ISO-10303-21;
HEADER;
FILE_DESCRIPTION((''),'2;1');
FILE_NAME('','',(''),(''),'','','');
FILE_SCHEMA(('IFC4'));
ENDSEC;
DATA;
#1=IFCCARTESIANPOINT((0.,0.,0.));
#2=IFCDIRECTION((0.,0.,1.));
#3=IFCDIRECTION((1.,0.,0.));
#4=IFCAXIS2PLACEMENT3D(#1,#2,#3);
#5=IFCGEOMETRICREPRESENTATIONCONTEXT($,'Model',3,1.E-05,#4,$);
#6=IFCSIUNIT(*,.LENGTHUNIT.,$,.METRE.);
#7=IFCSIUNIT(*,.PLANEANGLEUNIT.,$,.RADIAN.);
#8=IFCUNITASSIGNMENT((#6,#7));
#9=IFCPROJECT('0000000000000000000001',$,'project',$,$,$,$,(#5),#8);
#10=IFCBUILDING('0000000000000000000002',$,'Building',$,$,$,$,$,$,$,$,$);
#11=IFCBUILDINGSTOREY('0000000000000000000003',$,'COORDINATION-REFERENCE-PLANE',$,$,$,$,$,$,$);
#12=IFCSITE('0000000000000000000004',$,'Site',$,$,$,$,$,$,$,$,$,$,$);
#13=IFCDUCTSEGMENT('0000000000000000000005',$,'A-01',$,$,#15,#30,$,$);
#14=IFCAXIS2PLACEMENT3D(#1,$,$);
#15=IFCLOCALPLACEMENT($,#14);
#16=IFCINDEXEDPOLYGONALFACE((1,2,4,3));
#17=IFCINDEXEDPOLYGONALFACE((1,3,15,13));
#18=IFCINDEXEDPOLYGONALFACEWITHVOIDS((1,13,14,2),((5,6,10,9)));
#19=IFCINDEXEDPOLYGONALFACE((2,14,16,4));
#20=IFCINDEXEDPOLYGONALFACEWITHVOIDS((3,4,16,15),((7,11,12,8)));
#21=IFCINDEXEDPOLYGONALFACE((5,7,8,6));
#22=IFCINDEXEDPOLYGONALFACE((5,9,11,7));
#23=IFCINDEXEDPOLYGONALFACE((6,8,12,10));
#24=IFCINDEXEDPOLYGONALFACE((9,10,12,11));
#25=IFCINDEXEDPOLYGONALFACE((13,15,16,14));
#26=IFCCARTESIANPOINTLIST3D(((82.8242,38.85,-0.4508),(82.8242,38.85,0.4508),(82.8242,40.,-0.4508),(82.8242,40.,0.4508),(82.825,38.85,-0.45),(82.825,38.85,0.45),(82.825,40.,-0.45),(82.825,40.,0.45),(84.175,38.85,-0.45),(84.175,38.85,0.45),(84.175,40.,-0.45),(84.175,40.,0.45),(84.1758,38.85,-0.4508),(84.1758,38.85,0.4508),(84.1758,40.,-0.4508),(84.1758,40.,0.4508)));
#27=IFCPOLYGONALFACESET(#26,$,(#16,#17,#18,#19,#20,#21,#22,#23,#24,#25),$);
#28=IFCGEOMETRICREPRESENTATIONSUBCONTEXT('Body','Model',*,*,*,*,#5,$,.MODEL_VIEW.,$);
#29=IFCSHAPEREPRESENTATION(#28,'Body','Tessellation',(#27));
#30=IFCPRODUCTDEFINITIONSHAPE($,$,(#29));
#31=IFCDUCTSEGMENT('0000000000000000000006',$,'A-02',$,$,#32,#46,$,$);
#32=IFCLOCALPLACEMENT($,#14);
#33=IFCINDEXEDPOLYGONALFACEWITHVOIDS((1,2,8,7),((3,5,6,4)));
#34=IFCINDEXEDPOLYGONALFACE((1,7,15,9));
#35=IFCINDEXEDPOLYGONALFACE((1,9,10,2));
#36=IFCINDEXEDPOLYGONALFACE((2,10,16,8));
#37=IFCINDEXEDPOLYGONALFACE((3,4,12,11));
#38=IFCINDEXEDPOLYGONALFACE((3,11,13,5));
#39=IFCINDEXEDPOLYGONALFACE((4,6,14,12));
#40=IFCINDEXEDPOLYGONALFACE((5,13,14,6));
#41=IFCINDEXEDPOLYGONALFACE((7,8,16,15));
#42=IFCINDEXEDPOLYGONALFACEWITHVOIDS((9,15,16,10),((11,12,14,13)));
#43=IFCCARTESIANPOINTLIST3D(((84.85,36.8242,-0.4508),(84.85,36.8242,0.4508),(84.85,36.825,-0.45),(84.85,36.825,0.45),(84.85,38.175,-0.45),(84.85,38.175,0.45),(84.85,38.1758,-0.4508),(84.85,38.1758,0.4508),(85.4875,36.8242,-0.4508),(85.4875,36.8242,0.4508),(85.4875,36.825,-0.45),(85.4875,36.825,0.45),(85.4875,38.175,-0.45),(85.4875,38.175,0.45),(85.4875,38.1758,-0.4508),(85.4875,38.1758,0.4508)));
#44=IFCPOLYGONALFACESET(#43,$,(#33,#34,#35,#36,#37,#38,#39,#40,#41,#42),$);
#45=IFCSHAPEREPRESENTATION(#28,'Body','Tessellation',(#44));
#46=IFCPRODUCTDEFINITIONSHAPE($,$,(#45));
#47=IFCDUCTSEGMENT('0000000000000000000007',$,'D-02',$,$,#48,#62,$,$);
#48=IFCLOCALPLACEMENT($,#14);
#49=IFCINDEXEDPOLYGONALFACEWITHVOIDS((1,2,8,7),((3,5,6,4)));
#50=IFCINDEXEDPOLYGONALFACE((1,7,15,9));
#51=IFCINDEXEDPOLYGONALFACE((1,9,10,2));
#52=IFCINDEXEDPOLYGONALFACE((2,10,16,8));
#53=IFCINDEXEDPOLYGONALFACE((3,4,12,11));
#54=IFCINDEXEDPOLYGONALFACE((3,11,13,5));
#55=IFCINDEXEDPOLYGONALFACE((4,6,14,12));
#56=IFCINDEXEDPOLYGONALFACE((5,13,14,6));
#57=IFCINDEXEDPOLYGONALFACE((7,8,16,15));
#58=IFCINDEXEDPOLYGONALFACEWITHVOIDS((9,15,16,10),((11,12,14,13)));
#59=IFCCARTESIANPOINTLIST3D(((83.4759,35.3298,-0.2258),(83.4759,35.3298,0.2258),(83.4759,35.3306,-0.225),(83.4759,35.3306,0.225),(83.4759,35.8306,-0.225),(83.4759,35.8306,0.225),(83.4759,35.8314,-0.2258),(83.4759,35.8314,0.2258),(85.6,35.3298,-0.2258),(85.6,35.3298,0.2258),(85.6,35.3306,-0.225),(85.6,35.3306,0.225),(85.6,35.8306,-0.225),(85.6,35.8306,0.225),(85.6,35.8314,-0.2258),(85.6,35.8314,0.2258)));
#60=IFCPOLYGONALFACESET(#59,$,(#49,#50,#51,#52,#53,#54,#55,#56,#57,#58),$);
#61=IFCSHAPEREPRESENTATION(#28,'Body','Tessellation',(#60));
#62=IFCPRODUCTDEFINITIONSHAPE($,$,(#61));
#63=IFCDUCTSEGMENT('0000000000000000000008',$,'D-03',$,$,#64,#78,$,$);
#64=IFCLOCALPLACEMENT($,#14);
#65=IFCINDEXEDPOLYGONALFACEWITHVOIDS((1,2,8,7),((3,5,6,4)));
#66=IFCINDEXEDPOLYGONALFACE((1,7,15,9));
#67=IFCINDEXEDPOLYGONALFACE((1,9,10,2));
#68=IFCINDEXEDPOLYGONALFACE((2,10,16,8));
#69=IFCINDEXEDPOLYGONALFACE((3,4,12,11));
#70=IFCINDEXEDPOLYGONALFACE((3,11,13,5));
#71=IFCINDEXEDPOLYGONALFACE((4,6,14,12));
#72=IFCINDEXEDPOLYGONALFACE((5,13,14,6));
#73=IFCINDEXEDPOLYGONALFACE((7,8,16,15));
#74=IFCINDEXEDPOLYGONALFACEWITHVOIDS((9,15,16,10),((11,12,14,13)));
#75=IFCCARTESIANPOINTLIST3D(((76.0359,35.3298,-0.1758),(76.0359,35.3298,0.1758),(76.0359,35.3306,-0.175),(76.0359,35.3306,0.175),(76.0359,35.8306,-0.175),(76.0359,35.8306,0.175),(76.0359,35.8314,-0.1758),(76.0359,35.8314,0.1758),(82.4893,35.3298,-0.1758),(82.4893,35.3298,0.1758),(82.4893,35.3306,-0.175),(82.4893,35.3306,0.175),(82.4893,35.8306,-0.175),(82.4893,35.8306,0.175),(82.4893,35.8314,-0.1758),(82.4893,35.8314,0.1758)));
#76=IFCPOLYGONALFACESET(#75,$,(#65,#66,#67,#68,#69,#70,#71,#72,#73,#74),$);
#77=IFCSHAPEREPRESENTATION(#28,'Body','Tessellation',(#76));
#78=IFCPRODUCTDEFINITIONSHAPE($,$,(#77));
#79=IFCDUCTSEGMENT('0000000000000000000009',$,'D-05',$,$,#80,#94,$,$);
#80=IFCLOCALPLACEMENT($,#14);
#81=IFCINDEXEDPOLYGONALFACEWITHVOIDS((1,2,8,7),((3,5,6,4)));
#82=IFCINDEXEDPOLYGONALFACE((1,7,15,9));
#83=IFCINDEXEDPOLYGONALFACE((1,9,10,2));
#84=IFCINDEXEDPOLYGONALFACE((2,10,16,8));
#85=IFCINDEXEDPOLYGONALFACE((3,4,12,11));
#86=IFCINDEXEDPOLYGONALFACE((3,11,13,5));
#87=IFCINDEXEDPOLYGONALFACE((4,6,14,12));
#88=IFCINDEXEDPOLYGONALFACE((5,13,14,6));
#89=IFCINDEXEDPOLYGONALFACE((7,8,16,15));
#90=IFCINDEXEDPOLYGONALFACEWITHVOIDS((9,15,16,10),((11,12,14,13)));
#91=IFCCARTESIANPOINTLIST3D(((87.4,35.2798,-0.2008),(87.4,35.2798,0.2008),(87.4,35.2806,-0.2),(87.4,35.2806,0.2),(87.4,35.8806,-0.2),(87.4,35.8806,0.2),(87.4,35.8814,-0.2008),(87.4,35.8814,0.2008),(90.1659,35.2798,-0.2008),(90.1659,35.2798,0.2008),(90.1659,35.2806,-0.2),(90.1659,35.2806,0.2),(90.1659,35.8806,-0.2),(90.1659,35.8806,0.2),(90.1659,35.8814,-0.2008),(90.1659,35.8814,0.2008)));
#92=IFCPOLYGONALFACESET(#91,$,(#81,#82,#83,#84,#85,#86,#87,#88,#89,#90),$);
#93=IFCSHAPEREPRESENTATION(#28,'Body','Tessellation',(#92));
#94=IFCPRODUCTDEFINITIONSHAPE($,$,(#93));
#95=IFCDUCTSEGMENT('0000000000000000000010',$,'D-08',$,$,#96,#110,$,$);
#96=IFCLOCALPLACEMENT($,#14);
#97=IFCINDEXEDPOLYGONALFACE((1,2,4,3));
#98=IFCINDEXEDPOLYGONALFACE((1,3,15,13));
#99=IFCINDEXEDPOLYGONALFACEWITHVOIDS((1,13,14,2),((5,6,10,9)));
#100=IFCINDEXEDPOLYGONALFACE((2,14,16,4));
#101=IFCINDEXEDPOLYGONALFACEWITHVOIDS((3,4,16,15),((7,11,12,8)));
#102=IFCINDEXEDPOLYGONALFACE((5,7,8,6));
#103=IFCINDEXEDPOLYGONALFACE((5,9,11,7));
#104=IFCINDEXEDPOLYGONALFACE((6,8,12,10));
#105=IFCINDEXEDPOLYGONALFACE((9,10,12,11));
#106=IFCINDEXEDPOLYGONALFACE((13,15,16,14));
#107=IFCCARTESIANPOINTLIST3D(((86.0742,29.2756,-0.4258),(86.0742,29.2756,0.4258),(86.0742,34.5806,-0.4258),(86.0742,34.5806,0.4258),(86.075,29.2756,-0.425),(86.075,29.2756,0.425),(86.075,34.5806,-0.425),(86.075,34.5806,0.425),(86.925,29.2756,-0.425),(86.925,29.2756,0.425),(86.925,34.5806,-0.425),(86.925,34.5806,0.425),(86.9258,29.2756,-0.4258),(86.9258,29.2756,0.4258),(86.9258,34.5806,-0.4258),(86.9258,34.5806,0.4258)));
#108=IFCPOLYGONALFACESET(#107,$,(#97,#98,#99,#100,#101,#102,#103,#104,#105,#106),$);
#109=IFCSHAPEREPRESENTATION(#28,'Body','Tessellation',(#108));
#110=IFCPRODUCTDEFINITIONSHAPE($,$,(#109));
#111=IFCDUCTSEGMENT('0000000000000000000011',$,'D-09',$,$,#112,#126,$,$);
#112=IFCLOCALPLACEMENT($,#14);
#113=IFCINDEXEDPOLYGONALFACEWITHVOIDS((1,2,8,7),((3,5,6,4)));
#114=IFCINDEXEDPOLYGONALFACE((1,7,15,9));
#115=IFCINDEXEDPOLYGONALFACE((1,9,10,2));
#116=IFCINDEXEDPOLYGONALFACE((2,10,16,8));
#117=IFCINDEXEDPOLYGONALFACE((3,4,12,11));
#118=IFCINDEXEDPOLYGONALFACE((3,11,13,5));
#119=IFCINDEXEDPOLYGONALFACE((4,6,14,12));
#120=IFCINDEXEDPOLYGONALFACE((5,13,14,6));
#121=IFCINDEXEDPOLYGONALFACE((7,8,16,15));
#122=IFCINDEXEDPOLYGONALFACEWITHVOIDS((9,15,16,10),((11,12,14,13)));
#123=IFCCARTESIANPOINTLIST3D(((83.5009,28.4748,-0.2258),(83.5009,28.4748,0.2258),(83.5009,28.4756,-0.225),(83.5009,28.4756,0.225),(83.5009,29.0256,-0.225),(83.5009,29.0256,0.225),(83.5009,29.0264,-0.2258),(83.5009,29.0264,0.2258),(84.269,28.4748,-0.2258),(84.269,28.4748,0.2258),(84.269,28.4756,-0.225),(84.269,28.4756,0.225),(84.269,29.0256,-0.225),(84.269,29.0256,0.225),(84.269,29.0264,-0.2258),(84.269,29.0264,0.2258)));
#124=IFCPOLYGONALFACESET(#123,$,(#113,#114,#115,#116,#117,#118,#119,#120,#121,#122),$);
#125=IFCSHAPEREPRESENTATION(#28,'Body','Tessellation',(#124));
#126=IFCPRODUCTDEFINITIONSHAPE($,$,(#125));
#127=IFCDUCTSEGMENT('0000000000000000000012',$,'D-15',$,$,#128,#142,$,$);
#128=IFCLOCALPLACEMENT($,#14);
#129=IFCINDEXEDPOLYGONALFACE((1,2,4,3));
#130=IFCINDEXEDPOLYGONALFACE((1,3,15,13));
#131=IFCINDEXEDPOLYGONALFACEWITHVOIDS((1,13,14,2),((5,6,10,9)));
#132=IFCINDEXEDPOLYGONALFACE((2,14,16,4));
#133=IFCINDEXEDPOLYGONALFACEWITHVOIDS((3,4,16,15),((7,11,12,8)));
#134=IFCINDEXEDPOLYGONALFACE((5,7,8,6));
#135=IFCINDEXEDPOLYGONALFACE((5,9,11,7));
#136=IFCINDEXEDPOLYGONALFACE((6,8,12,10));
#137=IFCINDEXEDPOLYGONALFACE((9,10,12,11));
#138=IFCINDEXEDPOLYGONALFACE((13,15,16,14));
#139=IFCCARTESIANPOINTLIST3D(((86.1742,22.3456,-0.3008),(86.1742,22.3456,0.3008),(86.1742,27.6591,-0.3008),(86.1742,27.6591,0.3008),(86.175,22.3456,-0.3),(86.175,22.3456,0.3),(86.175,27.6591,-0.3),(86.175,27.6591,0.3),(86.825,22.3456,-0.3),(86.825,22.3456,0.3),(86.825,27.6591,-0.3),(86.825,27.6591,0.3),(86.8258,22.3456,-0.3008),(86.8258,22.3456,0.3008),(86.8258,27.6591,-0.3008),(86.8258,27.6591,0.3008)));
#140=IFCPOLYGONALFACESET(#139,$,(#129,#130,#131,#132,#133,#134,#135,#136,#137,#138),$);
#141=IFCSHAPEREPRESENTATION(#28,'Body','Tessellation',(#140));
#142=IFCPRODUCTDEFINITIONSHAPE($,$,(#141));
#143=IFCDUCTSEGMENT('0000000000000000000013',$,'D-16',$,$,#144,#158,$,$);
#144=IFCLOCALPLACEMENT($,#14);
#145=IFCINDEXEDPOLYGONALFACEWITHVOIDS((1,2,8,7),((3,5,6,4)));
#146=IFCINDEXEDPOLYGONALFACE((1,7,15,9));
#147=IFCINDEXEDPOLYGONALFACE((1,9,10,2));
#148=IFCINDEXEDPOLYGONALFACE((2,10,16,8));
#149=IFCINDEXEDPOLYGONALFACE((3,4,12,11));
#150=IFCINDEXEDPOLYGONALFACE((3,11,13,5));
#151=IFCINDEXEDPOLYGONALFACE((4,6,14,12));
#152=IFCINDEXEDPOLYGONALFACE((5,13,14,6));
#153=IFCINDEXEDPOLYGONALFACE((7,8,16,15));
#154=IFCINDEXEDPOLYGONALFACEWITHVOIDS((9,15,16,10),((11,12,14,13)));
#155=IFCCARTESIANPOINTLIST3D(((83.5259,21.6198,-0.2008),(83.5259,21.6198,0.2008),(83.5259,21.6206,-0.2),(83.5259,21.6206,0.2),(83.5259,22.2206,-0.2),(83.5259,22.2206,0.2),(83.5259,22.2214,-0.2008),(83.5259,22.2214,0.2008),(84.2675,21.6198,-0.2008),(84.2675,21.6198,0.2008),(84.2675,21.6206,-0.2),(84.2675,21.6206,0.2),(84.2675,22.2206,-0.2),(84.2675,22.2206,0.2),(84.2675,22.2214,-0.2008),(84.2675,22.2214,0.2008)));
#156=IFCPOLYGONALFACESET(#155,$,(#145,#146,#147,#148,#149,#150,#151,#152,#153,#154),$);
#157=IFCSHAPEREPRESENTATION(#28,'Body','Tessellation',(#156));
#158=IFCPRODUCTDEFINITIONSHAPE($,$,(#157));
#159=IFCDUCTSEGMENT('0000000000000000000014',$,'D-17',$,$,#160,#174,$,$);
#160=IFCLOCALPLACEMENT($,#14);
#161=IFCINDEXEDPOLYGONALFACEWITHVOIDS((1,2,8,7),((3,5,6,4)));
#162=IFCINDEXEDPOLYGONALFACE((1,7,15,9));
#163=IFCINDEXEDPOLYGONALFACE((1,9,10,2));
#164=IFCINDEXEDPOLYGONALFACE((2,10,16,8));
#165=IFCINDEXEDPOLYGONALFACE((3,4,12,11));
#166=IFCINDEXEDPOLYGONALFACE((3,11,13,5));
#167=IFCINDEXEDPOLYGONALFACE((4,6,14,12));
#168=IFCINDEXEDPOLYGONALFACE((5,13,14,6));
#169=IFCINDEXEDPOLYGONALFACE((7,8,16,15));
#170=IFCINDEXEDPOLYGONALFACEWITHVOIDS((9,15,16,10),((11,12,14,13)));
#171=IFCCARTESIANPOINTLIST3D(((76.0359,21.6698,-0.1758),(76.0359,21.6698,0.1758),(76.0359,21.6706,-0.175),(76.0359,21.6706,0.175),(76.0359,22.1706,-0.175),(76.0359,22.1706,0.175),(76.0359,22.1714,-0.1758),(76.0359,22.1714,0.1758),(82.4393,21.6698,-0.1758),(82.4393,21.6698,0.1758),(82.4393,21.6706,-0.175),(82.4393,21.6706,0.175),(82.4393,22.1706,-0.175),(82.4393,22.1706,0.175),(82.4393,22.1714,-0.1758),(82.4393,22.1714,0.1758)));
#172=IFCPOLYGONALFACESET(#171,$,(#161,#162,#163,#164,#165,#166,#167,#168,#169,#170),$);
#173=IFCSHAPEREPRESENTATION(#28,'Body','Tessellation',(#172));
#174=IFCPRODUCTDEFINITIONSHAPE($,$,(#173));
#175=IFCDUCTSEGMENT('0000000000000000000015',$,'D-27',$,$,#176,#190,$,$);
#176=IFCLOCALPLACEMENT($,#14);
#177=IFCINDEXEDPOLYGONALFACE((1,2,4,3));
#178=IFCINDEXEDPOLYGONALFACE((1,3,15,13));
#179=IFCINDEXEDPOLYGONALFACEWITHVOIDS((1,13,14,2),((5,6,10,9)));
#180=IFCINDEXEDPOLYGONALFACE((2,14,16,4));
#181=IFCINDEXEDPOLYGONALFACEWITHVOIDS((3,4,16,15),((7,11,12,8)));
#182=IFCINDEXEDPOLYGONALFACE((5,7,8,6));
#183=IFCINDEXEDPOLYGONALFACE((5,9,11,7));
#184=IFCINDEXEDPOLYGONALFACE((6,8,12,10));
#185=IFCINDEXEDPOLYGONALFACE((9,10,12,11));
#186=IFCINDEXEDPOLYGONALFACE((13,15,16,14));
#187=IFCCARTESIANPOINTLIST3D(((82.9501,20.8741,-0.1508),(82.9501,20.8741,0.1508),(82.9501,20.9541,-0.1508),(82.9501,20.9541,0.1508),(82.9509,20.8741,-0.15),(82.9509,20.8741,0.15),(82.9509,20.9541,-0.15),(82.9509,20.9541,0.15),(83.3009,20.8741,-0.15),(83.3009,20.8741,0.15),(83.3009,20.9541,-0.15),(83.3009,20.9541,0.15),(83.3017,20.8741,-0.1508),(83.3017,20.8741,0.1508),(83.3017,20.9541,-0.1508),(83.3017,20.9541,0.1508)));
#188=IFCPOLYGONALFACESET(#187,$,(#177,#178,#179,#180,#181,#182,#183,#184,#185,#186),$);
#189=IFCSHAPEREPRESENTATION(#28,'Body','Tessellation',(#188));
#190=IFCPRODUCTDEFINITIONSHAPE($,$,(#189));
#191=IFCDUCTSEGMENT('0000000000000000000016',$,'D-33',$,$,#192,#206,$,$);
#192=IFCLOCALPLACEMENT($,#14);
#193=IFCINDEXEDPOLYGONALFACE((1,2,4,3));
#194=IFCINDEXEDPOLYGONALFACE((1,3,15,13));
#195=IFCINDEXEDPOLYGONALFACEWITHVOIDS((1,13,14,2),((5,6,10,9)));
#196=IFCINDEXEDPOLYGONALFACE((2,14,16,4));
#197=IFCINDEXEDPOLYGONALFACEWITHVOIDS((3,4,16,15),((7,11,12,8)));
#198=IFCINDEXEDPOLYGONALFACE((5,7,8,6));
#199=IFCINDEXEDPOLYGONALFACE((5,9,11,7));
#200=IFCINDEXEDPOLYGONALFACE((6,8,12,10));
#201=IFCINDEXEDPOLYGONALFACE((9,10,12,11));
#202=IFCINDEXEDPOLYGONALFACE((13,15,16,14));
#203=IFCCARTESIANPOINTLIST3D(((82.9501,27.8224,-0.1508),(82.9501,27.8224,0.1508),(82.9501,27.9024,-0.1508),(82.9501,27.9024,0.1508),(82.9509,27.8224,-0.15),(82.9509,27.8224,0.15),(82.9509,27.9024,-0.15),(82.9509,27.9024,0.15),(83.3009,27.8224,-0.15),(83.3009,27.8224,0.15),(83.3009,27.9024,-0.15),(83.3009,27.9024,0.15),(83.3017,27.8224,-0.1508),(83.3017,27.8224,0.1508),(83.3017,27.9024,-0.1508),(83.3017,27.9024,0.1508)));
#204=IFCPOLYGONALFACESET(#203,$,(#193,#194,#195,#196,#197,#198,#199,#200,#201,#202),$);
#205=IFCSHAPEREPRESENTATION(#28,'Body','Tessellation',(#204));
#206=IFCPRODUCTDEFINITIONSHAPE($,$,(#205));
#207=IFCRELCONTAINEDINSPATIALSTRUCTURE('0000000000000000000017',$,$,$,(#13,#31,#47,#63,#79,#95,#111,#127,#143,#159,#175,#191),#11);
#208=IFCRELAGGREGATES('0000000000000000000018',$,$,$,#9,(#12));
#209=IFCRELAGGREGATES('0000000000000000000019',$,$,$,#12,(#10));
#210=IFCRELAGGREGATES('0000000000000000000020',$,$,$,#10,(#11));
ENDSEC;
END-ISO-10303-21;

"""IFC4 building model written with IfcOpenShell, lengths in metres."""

from ifc_helpers import new_model, si_unit, frame, origin, origin_with_axes, place, context, subcontext, project, spatial, hollow_rectangle, extrude, element, save


model = new_model("IFC4")

# Units and contexts
model_context = context("Model", 3, precision=1e-05, world=origin_with_axes())
body_context_1 = subcontext(model_context, "Body", "Model", "MODEL_VIEW")
ifc_project = project(units=[si_unit("LENGTHUNIT", "METRE"), si_unit("PLANEANGLEUNIT", "RADIAN")], contexts=[model_context])

# Site, building, storey
site = spatial("IfcSite", under=ifc_project, Name="Site")
building = spatial("IfcBuilding", under=site, Name="Building")
storey = spatial("IfcBuildingStorey", under=building, Name="COORDINATION-REFERENCE-PLANE")

# Duct segments
duct_segment_1_placement = place(None, frame((83.5, 38.85, 0.0), z_axis=(0.0, 1.0, 0.0), x_axis=(1.0, 0.0, 0.0)))
element("IfcDuctSegment", 1, at=duct_segment_1_placement, inside=storey, Name="A-01", context=body_context_1, shape_type="SweptSolid", body=[
    extrude(hollow_rectangle(XDim=1.3516, YDim=0.9016, WallThickness=0.0008), origin(), (0.0, 0.0, 1.0), 1.15),
])
duct_segment_2_placement = place(None, frame((84.85, 37.5, 0.0), z_axis=(1.0, 0.0, 0.0), x_axis=(0.0, 1.0, 0.0)))
element("IfcDuctSegment", 2, at=duct_segment_2_placement, inside=storey, Name="A-02", context=body_context_1, shape_type="SweptSolid", body=[
    extrude(hollow_rectangle(XDim=1.3516, YDim=0.9016, WallThickness=0.0008), origin(), (0.0, 0.0, 1.0), 0.6375),
])
duct_segment_3_placement = place(None, frame((83.4759, 35.5806, 0.0), z_axis=(1.0, 0.0, 0.0), x_axis=(0.0, 1.0, 0.0)))
element("IfcDuctSegment", 3, at=duct_segment_3_placement, inside=storey, Name="D-02", context=body_context_1, shape_type="SweptSolid", body=[
    extrude(hollow_rectangle(XDim=0.5016, YDim=0.4516, WallThickness=0.0008), origin(), (0.0, 0.0, 1.0), 2.1241),
])
duct_segment_4_placement = place(None, frame((76.0359, 35.5806, 0.0), z_axis=(1.0, 0.0, 0.0), x_axis=(0.0, 1.0, 0.0)))
element("IfcDuctSegment", 4, at=duct_segment_4_placement, inside=storey, Name="D-03", context=body_context_1, shape_type="SweptSolid", body=[
    extrude(hollow_rectangle(XDim=0.5016, YDim=0.3516, WallThickness=0.0008), origin(), (0.0, 0.0, 1.0), 6.4534),
])
duct_segment_5_placement = place(None, frame((87.4, 35.5806, 0.0), z_axis=(1.0, 0.0, 0.0), x_axis=(0.0, 1.0, 0.0)))
element("IfcDuctSegment", 5, at=duct_segment_5_placement, inside=storey, Name="D-05", context=body_context_1, shape_type="SweptSolid", body=[
    extrude(hollow_rectangle(XDim=0.6016, YDim=0.4016, WallThickness=0.0008), origin(), (0.0, 0.0, 1.0), 2.7659),
])
duct_segment_6_placement = place(None, frame((86.5, 29.2756, 0.0), z_axis=(0.0, 1.0, 0.0), x_axis=(1.0, 0.0, 0.0)))
element("IfcDuctSegment", 6, at=duct_segment_6_placement, inside=storey, Name="D-08", context=body_context_1, shape_type="SweptSolid", body=[
    extrude(hollow_rectangle(XDim=0.8516, YDim=0.8516, WallThickness=0.0008), origin(), (0.0, 0.0, 1.0), 5.305),
])
duct_segment_7_placement = place(None, frame((83.5009, 28.7506, 0.0), z_axis=(1.0, 0.0, 0.0), x_axis=(0.0, 1.0, 0.0)))
element("IfcDuctSegment", 7, at=duct_segment_7_placement, inside=storey, Name="D-09", context=body_context_1, shape_type="SweptSolid", body=[
    extrude(hollow_rectangle(XDim=0.5516, YDim=0.4516, WallThickness=0.0008), origin(), (0.0, 0.0, 1.0), 0.7681),
])
duct_segment_8_placement = place(None, frame((86.5, 22.3456, 0.0), z_axis=(0.0, 1.0, 0.0), x_axis=(1.0, 0.0, 0.0)))
element("IfcDuctSegment", 8, at=duct_segment_8_placement, inside=storey, Name="D-15", context=body_context_1, shape_type="SweptSolid", body=[
    extrude(hollow_rectangle(XDim=0.6516, YDim=0.6016, WallThickness=0.0008), origin(), (0.0, 0.0, 1.0), 5.3135),
])
duct_segment_9_placement = place(None, frame((83.5259, 21.9206, 0.0), z_axis=(1.0, 0.0, 0.0), x_axis=(0.0, 1.0, 0.0)))
element("IfcDuctSegment", 9, at=duct_segment_9_placement, inside=storey, Name="D-16", context=body_context_1, shape_type="SweptSolid", body=[
    extrude(hollow_rectangle(XDim=0.6016, YDim=0.4016, WallThickness=0.0008), origin(), (0.0, 0.0, 1.0), 0.7416),
])
duct_segment_10_placement = place(None, frame((76.0359, 21.9206, 0.0), z_axis=(1.0, 0.0, 0.0), x_axis=(0.0, 1.0, 0.0)))
element("IfcDuctSegment", 10, at=duct_segment_10_placement, inside=storey, Name="D-17", context=body_context_1, shape_type="SweptSolid", body=[
    extrude(hollow_rectangle(XDim=0.5016, YDim=0.3516, WallThickness=0.0008), origin(), (0.0, 0.0, 1.0), 6.4034),
])
for number, where, z_axis, x_axis, name in (
    (11, (83.1259, 20.8741, 0.0), (0.0, 1.0, 0.0), (1.0, 0.0, 0.0), "D-27"),
    (12, (83.1259, 27.8224, 0.0), (0.0, 1.0, 0.0), (1.0, 0.0, 0.0), "D-33"),
):
    element("IfcDuctSegment", number, at=place(None, frame(where, z_axis=z_axis, x_axis=x_axis)), inside=storey, Name=name, context=body_context_1, shape_type="SweptSolid", body=[
        extrude(hollow_rectangle(XDim=0.3516, YDim=0.3016, WallThickness=0.0008), origin(), (0.0, 0.0, 1.0), 0.08),
    ])

save(model, "model.ifc")
